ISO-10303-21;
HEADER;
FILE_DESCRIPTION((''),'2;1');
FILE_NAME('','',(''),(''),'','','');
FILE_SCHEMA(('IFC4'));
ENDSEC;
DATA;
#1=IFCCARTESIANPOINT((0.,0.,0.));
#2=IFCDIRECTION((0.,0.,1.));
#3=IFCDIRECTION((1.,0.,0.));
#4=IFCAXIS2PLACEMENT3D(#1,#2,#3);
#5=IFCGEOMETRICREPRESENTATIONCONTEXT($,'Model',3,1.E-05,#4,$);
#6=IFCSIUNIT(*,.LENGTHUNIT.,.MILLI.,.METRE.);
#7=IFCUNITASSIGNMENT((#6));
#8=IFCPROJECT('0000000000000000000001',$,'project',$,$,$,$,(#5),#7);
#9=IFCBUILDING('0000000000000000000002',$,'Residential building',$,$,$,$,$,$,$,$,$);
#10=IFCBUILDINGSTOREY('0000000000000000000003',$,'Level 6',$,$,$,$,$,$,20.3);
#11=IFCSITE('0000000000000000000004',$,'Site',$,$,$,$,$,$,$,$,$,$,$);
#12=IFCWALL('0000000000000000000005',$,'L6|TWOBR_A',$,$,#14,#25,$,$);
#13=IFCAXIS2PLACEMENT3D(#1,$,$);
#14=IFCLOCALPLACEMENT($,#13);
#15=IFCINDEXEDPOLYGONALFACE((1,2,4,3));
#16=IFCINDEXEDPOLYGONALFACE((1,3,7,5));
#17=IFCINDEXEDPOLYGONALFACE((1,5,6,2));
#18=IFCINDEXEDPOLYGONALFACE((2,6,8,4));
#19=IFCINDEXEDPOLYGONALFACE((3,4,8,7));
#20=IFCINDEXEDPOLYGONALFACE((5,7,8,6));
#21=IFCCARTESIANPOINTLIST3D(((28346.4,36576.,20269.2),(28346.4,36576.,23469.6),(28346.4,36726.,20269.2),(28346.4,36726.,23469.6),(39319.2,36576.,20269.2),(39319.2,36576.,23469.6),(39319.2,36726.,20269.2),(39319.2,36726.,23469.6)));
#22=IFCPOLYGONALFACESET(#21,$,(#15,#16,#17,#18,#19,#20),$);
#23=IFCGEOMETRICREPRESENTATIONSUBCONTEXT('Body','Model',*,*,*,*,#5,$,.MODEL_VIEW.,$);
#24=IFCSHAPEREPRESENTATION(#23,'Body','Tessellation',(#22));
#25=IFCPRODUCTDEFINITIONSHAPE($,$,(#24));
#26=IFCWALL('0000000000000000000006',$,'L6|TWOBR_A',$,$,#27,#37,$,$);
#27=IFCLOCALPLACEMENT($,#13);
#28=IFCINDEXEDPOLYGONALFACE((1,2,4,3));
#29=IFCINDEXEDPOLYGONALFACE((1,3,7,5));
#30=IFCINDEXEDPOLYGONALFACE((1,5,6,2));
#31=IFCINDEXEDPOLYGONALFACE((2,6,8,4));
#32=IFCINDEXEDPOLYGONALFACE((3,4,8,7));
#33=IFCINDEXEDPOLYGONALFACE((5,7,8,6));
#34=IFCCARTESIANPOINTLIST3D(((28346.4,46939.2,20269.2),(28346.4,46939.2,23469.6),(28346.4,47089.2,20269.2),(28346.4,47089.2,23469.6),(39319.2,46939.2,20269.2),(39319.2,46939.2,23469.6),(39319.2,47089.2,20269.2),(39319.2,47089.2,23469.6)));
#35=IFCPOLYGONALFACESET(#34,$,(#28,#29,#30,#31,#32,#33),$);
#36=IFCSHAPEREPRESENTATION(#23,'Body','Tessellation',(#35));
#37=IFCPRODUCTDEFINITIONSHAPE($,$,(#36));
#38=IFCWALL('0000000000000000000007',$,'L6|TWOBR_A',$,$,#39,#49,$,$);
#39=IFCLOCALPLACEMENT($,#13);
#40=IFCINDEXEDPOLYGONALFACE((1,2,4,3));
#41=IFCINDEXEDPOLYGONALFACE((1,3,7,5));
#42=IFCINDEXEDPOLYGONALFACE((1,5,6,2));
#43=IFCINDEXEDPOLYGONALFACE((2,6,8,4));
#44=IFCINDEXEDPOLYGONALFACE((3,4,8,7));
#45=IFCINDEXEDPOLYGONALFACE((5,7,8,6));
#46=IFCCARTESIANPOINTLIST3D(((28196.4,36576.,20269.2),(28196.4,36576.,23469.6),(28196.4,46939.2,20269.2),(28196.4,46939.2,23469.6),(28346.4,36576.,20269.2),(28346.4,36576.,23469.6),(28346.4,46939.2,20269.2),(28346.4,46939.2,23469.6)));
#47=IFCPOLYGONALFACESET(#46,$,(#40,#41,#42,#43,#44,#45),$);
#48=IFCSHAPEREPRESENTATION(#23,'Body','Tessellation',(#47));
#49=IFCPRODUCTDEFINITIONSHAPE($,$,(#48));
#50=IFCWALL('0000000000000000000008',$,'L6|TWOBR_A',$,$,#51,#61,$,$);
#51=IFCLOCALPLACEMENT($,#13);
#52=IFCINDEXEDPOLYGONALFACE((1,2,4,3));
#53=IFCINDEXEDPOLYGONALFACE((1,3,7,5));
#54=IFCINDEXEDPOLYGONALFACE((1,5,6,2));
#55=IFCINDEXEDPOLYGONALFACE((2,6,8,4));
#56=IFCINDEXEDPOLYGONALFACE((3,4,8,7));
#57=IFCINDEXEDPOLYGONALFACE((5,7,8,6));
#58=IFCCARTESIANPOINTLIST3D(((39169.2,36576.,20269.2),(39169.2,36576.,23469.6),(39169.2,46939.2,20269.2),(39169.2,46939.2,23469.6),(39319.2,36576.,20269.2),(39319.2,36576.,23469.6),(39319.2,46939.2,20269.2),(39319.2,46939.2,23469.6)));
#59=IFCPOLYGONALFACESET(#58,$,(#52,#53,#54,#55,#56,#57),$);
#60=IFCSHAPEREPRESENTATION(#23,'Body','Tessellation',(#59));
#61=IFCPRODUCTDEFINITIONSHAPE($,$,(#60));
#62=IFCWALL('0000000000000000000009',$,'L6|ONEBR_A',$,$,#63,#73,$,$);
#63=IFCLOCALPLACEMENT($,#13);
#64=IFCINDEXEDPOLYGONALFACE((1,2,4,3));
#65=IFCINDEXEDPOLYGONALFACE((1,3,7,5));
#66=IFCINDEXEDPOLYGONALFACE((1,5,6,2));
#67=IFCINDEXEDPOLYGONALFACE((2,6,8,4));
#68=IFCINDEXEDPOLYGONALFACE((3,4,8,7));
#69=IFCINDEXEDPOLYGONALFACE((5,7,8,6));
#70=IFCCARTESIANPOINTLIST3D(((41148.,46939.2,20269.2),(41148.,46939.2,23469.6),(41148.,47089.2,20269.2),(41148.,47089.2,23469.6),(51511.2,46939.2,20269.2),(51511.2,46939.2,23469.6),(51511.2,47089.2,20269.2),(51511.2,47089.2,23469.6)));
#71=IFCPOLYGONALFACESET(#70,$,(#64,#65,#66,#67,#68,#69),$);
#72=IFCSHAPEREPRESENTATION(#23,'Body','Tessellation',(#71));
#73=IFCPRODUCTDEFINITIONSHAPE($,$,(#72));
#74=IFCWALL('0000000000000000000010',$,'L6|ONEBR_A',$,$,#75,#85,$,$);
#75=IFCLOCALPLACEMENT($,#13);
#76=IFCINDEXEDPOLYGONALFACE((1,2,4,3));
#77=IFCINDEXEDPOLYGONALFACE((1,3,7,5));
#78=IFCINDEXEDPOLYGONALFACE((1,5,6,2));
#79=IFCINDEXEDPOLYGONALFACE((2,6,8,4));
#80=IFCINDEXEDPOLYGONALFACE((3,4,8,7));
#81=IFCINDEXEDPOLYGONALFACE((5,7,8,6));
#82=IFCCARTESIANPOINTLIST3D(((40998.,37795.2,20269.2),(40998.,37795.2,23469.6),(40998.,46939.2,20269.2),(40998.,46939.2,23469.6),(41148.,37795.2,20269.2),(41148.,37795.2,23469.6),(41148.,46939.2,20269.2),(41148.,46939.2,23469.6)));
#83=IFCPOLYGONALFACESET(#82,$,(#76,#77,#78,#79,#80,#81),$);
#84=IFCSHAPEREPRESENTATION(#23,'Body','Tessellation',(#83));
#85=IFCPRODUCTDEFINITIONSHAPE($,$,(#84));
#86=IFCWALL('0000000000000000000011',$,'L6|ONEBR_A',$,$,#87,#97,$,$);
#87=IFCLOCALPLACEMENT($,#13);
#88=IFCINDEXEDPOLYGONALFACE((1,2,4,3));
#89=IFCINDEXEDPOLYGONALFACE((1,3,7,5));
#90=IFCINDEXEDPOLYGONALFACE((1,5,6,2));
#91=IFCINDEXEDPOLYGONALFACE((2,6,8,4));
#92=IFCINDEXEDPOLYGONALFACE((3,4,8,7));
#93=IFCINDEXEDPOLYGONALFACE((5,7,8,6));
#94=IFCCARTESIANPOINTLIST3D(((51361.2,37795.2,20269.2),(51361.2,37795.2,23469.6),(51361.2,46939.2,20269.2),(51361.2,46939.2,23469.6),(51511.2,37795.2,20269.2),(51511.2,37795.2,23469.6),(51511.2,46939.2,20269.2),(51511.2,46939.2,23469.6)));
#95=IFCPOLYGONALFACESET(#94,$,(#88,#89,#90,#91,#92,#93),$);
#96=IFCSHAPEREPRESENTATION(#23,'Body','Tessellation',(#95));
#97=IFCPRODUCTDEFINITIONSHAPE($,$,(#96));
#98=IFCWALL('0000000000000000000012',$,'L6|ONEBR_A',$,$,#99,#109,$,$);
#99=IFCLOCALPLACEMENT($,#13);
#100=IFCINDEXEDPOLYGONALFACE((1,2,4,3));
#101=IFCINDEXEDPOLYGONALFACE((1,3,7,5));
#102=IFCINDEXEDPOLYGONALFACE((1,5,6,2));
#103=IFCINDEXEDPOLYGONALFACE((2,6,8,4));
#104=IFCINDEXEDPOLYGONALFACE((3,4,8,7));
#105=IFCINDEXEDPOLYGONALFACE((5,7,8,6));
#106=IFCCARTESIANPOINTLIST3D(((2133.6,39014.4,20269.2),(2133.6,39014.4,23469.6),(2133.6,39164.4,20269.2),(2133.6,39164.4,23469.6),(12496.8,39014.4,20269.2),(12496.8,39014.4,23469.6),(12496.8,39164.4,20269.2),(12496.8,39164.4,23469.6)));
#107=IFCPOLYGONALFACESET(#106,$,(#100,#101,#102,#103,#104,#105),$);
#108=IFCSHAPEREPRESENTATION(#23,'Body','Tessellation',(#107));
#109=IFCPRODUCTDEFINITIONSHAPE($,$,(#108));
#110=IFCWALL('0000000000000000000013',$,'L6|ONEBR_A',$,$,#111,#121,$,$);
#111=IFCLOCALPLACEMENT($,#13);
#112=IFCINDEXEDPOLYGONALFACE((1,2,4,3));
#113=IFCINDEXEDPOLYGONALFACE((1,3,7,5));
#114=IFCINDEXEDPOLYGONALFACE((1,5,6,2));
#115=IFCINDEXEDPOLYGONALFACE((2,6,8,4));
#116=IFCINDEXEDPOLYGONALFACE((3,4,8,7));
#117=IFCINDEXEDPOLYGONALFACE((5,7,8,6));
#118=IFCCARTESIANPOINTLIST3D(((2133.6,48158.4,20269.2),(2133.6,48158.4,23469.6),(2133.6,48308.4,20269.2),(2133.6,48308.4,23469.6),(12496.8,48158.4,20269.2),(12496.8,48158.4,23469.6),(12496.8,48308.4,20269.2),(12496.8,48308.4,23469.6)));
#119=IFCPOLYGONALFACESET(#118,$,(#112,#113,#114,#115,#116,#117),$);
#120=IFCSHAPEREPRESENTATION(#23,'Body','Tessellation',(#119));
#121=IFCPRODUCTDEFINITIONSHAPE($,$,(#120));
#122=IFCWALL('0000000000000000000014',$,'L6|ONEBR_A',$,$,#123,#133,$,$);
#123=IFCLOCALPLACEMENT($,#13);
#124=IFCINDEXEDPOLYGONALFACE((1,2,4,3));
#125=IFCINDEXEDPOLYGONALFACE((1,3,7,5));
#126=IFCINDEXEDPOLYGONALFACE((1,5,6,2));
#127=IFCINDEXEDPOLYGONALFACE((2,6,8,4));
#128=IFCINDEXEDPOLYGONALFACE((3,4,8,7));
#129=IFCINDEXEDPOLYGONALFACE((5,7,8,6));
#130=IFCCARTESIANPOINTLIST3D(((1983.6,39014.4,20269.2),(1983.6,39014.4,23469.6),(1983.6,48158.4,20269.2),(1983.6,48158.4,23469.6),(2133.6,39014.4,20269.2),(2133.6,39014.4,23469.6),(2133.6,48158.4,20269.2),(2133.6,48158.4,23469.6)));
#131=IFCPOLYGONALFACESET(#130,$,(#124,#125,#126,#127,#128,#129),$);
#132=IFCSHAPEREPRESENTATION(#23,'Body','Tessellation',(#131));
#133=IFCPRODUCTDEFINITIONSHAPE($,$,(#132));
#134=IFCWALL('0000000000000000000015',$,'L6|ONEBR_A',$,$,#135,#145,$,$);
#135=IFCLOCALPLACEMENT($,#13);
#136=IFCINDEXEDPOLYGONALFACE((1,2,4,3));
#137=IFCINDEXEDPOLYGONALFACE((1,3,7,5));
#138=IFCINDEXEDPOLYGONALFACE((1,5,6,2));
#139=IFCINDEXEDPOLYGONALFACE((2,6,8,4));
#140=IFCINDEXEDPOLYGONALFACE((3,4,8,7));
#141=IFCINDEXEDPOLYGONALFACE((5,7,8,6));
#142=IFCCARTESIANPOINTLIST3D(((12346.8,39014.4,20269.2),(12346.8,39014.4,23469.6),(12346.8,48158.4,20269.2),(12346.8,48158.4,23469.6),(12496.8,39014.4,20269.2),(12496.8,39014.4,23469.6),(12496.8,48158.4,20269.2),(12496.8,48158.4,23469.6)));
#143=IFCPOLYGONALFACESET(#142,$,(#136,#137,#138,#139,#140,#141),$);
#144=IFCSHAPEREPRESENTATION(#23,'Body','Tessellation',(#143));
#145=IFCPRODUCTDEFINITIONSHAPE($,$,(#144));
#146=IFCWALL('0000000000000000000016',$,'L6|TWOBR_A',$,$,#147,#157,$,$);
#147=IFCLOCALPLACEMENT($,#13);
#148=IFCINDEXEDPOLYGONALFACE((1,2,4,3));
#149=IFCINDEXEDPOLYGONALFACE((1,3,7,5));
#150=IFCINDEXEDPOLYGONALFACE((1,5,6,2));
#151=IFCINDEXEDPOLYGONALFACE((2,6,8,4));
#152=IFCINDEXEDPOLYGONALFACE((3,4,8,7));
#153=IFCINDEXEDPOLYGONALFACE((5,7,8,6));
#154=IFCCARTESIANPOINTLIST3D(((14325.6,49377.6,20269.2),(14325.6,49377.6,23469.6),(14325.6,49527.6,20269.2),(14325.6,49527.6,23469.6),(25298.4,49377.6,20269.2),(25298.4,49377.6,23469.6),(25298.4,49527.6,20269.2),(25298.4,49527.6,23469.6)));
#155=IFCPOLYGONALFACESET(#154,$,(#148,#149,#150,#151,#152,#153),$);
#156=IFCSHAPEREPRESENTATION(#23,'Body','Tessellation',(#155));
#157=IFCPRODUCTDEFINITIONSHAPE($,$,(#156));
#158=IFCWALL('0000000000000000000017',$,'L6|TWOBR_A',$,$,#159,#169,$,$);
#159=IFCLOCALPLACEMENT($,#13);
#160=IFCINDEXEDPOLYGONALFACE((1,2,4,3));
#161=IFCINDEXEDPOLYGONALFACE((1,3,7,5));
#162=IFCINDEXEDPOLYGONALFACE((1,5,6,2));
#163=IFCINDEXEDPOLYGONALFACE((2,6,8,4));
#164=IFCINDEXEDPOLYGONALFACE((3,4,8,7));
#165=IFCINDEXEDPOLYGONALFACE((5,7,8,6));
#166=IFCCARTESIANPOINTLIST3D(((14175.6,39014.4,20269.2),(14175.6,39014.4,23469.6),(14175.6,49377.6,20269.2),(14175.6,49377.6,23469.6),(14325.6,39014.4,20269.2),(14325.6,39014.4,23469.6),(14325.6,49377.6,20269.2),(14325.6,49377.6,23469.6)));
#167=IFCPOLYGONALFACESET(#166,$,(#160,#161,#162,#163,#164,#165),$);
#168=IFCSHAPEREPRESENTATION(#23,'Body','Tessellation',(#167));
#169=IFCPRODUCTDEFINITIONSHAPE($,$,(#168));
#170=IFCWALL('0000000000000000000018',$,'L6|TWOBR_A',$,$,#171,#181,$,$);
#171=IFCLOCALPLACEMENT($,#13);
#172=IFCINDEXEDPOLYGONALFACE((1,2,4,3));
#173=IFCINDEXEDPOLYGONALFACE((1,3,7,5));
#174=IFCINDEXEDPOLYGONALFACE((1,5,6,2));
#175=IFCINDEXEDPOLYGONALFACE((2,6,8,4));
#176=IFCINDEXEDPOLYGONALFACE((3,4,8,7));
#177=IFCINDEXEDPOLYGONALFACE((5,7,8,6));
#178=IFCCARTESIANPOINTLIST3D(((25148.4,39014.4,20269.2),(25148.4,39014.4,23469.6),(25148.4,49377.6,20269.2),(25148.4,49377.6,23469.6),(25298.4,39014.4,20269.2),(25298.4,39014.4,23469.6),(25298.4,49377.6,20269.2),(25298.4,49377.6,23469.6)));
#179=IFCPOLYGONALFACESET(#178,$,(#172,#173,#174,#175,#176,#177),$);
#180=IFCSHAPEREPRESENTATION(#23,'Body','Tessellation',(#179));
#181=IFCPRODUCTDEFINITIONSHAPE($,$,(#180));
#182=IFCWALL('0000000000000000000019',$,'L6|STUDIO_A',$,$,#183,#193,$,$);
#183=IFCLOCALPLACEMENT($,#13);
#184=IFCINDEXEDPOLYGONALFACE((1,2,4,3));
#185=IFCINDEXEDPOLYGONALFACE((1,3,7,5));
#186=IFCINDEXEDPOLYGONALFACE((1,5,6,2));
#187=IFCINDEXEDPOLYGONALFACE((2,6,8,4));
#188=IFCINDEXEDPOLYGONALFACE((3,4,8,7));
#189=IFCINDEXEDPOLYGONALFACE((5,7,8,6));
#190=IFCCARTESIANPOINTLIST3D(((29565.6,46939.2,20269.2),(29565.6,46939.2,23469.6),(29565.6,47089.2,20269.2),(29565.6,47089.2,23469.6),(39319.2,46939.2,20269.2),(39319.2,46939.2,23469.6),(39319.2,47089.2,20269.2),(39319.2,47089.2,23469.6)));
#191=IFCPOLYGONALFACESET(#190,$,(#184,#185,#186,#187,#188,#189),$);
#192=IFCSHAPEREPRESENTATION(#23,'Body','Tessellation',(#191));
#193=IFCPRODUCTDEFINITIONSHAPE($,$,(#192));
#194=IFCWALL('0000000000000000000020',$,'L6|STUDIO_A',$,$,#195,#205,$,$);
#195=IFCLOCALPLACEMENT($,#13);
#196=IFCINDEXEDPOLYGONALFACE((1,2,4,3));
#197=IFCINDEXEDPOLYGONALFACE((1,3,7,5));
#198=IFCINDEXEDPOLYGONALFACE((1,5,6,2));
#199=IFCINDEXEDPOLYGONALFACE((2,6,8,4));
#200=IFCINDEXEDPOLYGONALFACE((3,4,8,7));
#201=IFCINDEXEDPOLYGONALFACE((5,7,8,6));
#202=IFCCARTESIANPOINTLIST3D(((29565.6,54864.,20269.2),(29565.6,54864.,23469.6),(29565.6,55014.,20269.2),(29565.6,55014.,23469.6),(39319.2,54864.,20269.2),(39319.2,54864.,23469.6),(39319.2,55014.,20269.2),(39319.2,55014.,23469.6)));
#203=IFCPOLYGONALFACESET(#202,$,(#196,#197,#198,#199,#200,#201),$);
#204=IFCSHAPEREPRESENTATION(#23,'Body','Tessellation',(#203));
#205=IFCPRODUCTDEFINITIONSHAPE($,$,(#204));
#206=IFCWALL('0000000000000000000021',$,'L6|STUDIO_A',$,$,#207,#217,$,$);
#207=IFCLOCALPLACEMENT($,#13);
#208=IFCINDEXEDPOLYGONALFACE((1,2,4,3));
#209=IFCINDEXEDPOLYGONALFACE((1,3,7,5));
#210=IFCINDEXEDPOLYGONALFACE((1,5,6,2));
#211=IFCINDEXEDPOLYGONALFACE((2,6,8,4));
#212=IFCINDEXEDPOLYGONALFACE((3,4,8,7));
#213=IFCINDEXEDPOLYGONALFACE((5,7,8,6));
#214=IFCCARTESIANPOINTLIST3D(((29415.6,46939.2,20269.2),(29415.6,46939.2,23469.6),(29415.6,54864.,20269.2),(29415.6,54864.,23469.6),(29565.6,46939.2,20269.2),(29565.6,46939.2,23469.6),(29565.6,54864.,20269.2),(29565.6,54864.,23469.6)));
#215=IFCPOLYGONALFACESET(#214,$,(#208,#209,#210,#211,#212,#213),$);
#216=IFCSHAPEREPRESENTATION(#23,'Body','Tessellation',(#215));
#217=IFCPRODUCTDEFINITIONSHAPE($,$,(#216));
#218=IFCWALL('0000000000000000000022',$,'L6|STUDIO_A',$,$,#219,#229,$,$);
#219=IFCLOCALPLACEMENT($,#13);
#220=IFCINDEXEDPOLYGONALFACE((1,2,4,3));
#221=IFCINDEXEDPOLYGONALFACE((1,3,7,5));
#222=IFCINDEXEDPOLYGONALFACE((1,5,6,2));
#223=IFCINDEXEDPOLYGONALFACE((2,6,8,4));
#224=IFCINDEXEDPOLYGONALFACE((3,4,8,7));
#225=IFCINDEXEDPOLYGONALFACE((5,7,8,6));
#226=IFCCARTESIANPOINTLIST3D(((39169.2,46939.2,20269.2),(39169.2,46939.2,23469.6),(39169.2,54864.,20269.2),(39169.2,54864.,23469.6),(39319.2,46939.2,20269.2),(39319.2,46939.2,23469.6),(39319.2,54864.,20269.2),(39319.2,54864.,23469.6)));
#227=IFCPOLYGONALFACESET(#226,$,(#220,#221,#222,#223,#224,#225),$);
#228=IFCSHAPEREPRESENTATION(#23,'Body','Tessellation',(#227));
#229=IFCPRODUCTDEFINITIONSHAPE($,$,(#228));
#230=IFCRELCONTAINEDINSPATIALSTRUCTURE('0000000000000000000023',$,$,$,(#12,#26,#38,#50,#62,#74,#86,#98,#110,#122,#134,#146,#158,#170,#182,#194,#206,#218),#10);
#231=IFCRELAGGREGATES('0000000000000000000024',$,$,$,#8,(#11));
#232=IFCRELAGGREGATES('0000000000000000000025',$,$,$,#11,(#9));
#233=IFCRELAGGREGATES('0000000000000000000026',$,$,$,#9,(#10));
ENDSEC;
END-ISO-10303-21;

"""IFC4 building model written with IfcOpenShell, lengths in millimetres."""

from ifc_helpers import new_model, si_unit, frame, origin_with_axes, place, context, subcontext, project, spatial, indexed_curve, outline, extrude, element, save


model = new_model("IFC4")

# Units and contexts
model_context = context("Model", 3, precision=1e-05, world=origin_with_axes())
body_context = subcontext(model_context, "Body", "Model", "MODEL_VIEW")
ifc_project = project(units=[si_unit("LENGTHUNIT", "METRE", prefix="MILLI")], contexts=[model_context])

# Site, building, storey
site = spatial("IfcSite", under=ifc_project, Name="Site")
building = spatial("IfcBuilding", under=site, Name="Residential building")
storey = spatial("IfcBuildingStorey", under=building, Name="Level 6", Elevation=20.3)

# Walls
for number, where, z_axis, x_axis, name in (
    (1, (28346.4, 36576.0, 20269.2), (0.0, 0.0, 1.0), (1.0, 0.0, 0.0), "L6|TWOBR_A"),
    (2, (28346.4, 46939.2, 20269.2), (0.0, 0.0, 1.0), (1.0, 0.0, 0.0), "L6|TWOBR_A"),
):
    element("IfcWall", number, at=place(None, frame(where, z_axis=z_axis, x_axis=x_axis)), inside=storey, Name=name, context=body_context, shape_type="SweptSolid", body=[
        extrude(outline(indexed_curve([(0.0, 0.0), (0.0, 150.0), (10972.8, 150.0), (10972.8, 0.0), (0.0, 0.0)], self_intersect=False)), origin_with_axes(), (0.0, 0.0, 1.0), 3200.4),
    ])
for number, where, z_axis, x_axis, name in (
    (3, (28346.4, 36576.0, 20269.2), (0.0, 0.0, 1.0), (0.0, 1.0, 0.0), "L6|TWOBR_A"),
    (4, (39319.2, 36576.0, 20269.2), (0.0, 0.0, 1.0), (0.0, 1.0, 0.0), "L6|TWOBR_A"),
    (5, (41148.0, 46939.2, 20269.2), (0.0, 0.0, 1.0), (1.0, 0.0, 0.0), "L6|ONEBR_A"),
):
    element("IfcWall", number, at=place(None, frame(where, z_axis=z_axis, x_axis=x_axis)), inside=storey, Name=name, context=body_context, shape_type="SweptSolid", body=[
        extrude(outline(indexed_curve([(0.0, 0.0), (0.0, 150.0), (10363.2, 150.0), (10363.2, 0.0), (0.0, 0.0)], self_intersect=False)), origin_with_axes(), (0.0, 0.0, 1.0), 3200.4),
    ])
for number, where, z_axis, x_axis, name in (
    (6, (41148.0, 37795.2, 20269.2), (0.0, 0.0, 1.0), (0.0, 1.0, 0.0), "L6|ONEBR_A"),
    (7, (51511.2, 37795.2, 20269.2), (0.0, 0.0, 1.0), (0.0, 1.0, 0.0), "L6|ONEBR_A"),
):
    element("IfcWall", number, at=place(None, frame(where, z_axis=z_axis, x_axis=x_axis)), inside=storey, Name=name, context=body_context, shape_type="SweptSolid", body=[
        extrude(outline(indexed_curve([(0.0, 0.0), (0.0, 150.0), (9144.0, 150.0), (9144.0, 0.0), (0.0, 0.0)], self_intersect=False)), origin_with_axes(), (0.0, 0.0, 1.0), 3200.4),
    ])
for number, where, z_axis, x_axis, name in (
    (8, (2133.6, 39014.4, 20269.2), (0.0, 0.0, 1.0), (1.0, 0.0, 0.0), "L6|ONEBR_A"),
    (9, (2133.6, 48158.4, 20269.2), (0.0, 0.0, 1.0), (1.0, 0.0, 0.0), "L6|ONEBR_A"),
):
    element("IfcWall", number, at=place(None, frame(where, z_axis=z_axis, x_axis=x_axis)), inside=storey, Name=name, context=body_context, shape_type="SweptSolid", body=[
        extrude(outline(indexed_curve([(0.0, 0.0), (0.0, 150.0), (10363.2, 150.0), (10363.2, 0.0), (0.0, 0.0)], self_intersect=False)), origin_with_axes(), (0.0, 0.0, 1.0), 3200.4),
    ])
for number, where, z_axis, x_axis, name in (
    (10, (2133.6, 39014.4, 20269.2), (0.0, 0.0, 1.0), (0.0, 1.0, 0.0), "L6|ONEBR_A"),
    (11, (12496.8, 39014.4, 20269.2), (0.0, 0.0, 1.0), (0.0, 1.0, 0.0), "L6|ONEBR_A"),
):
    element("IfcWall", number, at=place(None, frame(where, z_axis=z_axis, x_axis=x_axis)), inside=storey, Name=name, context=body_context, shape_type="SweptSolid", body=[
        extrude(outline(indexed_curve([(0.0, 0.0), (0.0, 150.0), (9144.0, 150.0), (9144.0, 0.0), (0.0, 0.0)], self_intersect=False)), origin_with_axes(), (0.0, 0.0, 1.0), 3200.4),
    ])
for number, where, z_axis, x_axis, name in (
    (12, (14325.6, 49377.6, 20269.2), (0.0, 0.0, 1.0), (1.0, 0.0, 0.0), "L6|TWOBR_A"),
):
    element("IfcWall", number, at=place(None, frame(where, z_axis=z_axis, x_axis=x_axis)), inside=storey, Name=name, context=body_context, shape_type="SweptSolid", body=[
        extrude(outline(indexed_curve([(0.0, 0.0), (0.0, 150.0), (10972.8, 150.0), (10972.8, 0.0), (0.0, 0.0)], self_intersect=False)), origin_with_axes(), (0.0, 0.0, 1.0), 3200.4),
    ])
for number, where, z_axis, x_axis, name in (
    (13, (14325.6, 39014.4, 20269.2), (0.0, 0.0, 1.0), (0.0, 1.0, 0.0), "L6|TWOBR_A"),
    (14, (25298.4, 39014.4, 20269.2), (0.0, 0.0, 1.0), (0.0, 1.0, 0.0), "L6|TWOBR_A"),
):
    element("IfcWall", number, at=place(None, frame(where, z_axis=z_axis, x_axis=x_axis)), inside=storey, Name=name, context=body_context, shape_type="SweptSolid", body=[
        extrude(outline(indexed_curve([(0.0, 0.0), (0.0, 150.0), (10363.2, 150.0), (10363.2, 0.0), (0.0, 0.0)], self_intersect=False)), origin_with_axes(), (0.0, 0.0, 1.0), 3200.4),
    ])
for number, where, z_axis, x_axis, name in (
    (15, (29565.6, 46939.2, 20269.2), (0.0, 0.0, 1.0), (1.0, 0.0, 0.0), "L6|STUDIO_A"),
    (16, (29565.6, 54864.0, 20269.2), (0.0, 0.0, 1.0), (1.0, 0.0, 0.0), "L6|STUDIO_A"),
):
    element("IfcWall", number, at=place(None, frame(where, z_axis=z_axis, x_axis=x_axis)), inside=storey, Name=name, context=body_context, shape_type="SweptSolid", body=[
        extrude(outline(indexed_curve([(0.0, 0.0), (0.0, 150.0), (9753.6, 150.0), (9753.6, 0.0), (0.0, 0.0)], self_intersect=False)), origin_with_axes(), (0.0, 0.0, 1.0), 3200.4),
    ])
for number, where, z_axis, x_axis, name in (
    (17, (29565.6, 46939.2, 20269.2), (0.0, 0.0, 1.0), (0.0, 1.0, 0.0), "L6|STUDIO_A"),
    (18, (39319.2, 46939.2, 20269.2), (0.0, 0.0, 1.0), (0.0, 1.0, 0.0), "L6|STUDIO_A"),
):
    element("IfcWall", number, at=place(None, frame(where, z_axis=z_axis, x_axis=x_axis)), inside=storey, Name=name, context=body_context, shape_type="SweptSolid", body=[
        extrude(outline(indexed_curve([(0.0, 0.0), (0.0, 150.0), (7924.8, 150.0), (7924.8, 0.0), (0.0, 0.0)], self_intersect=False)), origin_with_axes(), (0.0, 0.0, 1.0), 3200.4),
    ])

save(model, "model.ifc")
